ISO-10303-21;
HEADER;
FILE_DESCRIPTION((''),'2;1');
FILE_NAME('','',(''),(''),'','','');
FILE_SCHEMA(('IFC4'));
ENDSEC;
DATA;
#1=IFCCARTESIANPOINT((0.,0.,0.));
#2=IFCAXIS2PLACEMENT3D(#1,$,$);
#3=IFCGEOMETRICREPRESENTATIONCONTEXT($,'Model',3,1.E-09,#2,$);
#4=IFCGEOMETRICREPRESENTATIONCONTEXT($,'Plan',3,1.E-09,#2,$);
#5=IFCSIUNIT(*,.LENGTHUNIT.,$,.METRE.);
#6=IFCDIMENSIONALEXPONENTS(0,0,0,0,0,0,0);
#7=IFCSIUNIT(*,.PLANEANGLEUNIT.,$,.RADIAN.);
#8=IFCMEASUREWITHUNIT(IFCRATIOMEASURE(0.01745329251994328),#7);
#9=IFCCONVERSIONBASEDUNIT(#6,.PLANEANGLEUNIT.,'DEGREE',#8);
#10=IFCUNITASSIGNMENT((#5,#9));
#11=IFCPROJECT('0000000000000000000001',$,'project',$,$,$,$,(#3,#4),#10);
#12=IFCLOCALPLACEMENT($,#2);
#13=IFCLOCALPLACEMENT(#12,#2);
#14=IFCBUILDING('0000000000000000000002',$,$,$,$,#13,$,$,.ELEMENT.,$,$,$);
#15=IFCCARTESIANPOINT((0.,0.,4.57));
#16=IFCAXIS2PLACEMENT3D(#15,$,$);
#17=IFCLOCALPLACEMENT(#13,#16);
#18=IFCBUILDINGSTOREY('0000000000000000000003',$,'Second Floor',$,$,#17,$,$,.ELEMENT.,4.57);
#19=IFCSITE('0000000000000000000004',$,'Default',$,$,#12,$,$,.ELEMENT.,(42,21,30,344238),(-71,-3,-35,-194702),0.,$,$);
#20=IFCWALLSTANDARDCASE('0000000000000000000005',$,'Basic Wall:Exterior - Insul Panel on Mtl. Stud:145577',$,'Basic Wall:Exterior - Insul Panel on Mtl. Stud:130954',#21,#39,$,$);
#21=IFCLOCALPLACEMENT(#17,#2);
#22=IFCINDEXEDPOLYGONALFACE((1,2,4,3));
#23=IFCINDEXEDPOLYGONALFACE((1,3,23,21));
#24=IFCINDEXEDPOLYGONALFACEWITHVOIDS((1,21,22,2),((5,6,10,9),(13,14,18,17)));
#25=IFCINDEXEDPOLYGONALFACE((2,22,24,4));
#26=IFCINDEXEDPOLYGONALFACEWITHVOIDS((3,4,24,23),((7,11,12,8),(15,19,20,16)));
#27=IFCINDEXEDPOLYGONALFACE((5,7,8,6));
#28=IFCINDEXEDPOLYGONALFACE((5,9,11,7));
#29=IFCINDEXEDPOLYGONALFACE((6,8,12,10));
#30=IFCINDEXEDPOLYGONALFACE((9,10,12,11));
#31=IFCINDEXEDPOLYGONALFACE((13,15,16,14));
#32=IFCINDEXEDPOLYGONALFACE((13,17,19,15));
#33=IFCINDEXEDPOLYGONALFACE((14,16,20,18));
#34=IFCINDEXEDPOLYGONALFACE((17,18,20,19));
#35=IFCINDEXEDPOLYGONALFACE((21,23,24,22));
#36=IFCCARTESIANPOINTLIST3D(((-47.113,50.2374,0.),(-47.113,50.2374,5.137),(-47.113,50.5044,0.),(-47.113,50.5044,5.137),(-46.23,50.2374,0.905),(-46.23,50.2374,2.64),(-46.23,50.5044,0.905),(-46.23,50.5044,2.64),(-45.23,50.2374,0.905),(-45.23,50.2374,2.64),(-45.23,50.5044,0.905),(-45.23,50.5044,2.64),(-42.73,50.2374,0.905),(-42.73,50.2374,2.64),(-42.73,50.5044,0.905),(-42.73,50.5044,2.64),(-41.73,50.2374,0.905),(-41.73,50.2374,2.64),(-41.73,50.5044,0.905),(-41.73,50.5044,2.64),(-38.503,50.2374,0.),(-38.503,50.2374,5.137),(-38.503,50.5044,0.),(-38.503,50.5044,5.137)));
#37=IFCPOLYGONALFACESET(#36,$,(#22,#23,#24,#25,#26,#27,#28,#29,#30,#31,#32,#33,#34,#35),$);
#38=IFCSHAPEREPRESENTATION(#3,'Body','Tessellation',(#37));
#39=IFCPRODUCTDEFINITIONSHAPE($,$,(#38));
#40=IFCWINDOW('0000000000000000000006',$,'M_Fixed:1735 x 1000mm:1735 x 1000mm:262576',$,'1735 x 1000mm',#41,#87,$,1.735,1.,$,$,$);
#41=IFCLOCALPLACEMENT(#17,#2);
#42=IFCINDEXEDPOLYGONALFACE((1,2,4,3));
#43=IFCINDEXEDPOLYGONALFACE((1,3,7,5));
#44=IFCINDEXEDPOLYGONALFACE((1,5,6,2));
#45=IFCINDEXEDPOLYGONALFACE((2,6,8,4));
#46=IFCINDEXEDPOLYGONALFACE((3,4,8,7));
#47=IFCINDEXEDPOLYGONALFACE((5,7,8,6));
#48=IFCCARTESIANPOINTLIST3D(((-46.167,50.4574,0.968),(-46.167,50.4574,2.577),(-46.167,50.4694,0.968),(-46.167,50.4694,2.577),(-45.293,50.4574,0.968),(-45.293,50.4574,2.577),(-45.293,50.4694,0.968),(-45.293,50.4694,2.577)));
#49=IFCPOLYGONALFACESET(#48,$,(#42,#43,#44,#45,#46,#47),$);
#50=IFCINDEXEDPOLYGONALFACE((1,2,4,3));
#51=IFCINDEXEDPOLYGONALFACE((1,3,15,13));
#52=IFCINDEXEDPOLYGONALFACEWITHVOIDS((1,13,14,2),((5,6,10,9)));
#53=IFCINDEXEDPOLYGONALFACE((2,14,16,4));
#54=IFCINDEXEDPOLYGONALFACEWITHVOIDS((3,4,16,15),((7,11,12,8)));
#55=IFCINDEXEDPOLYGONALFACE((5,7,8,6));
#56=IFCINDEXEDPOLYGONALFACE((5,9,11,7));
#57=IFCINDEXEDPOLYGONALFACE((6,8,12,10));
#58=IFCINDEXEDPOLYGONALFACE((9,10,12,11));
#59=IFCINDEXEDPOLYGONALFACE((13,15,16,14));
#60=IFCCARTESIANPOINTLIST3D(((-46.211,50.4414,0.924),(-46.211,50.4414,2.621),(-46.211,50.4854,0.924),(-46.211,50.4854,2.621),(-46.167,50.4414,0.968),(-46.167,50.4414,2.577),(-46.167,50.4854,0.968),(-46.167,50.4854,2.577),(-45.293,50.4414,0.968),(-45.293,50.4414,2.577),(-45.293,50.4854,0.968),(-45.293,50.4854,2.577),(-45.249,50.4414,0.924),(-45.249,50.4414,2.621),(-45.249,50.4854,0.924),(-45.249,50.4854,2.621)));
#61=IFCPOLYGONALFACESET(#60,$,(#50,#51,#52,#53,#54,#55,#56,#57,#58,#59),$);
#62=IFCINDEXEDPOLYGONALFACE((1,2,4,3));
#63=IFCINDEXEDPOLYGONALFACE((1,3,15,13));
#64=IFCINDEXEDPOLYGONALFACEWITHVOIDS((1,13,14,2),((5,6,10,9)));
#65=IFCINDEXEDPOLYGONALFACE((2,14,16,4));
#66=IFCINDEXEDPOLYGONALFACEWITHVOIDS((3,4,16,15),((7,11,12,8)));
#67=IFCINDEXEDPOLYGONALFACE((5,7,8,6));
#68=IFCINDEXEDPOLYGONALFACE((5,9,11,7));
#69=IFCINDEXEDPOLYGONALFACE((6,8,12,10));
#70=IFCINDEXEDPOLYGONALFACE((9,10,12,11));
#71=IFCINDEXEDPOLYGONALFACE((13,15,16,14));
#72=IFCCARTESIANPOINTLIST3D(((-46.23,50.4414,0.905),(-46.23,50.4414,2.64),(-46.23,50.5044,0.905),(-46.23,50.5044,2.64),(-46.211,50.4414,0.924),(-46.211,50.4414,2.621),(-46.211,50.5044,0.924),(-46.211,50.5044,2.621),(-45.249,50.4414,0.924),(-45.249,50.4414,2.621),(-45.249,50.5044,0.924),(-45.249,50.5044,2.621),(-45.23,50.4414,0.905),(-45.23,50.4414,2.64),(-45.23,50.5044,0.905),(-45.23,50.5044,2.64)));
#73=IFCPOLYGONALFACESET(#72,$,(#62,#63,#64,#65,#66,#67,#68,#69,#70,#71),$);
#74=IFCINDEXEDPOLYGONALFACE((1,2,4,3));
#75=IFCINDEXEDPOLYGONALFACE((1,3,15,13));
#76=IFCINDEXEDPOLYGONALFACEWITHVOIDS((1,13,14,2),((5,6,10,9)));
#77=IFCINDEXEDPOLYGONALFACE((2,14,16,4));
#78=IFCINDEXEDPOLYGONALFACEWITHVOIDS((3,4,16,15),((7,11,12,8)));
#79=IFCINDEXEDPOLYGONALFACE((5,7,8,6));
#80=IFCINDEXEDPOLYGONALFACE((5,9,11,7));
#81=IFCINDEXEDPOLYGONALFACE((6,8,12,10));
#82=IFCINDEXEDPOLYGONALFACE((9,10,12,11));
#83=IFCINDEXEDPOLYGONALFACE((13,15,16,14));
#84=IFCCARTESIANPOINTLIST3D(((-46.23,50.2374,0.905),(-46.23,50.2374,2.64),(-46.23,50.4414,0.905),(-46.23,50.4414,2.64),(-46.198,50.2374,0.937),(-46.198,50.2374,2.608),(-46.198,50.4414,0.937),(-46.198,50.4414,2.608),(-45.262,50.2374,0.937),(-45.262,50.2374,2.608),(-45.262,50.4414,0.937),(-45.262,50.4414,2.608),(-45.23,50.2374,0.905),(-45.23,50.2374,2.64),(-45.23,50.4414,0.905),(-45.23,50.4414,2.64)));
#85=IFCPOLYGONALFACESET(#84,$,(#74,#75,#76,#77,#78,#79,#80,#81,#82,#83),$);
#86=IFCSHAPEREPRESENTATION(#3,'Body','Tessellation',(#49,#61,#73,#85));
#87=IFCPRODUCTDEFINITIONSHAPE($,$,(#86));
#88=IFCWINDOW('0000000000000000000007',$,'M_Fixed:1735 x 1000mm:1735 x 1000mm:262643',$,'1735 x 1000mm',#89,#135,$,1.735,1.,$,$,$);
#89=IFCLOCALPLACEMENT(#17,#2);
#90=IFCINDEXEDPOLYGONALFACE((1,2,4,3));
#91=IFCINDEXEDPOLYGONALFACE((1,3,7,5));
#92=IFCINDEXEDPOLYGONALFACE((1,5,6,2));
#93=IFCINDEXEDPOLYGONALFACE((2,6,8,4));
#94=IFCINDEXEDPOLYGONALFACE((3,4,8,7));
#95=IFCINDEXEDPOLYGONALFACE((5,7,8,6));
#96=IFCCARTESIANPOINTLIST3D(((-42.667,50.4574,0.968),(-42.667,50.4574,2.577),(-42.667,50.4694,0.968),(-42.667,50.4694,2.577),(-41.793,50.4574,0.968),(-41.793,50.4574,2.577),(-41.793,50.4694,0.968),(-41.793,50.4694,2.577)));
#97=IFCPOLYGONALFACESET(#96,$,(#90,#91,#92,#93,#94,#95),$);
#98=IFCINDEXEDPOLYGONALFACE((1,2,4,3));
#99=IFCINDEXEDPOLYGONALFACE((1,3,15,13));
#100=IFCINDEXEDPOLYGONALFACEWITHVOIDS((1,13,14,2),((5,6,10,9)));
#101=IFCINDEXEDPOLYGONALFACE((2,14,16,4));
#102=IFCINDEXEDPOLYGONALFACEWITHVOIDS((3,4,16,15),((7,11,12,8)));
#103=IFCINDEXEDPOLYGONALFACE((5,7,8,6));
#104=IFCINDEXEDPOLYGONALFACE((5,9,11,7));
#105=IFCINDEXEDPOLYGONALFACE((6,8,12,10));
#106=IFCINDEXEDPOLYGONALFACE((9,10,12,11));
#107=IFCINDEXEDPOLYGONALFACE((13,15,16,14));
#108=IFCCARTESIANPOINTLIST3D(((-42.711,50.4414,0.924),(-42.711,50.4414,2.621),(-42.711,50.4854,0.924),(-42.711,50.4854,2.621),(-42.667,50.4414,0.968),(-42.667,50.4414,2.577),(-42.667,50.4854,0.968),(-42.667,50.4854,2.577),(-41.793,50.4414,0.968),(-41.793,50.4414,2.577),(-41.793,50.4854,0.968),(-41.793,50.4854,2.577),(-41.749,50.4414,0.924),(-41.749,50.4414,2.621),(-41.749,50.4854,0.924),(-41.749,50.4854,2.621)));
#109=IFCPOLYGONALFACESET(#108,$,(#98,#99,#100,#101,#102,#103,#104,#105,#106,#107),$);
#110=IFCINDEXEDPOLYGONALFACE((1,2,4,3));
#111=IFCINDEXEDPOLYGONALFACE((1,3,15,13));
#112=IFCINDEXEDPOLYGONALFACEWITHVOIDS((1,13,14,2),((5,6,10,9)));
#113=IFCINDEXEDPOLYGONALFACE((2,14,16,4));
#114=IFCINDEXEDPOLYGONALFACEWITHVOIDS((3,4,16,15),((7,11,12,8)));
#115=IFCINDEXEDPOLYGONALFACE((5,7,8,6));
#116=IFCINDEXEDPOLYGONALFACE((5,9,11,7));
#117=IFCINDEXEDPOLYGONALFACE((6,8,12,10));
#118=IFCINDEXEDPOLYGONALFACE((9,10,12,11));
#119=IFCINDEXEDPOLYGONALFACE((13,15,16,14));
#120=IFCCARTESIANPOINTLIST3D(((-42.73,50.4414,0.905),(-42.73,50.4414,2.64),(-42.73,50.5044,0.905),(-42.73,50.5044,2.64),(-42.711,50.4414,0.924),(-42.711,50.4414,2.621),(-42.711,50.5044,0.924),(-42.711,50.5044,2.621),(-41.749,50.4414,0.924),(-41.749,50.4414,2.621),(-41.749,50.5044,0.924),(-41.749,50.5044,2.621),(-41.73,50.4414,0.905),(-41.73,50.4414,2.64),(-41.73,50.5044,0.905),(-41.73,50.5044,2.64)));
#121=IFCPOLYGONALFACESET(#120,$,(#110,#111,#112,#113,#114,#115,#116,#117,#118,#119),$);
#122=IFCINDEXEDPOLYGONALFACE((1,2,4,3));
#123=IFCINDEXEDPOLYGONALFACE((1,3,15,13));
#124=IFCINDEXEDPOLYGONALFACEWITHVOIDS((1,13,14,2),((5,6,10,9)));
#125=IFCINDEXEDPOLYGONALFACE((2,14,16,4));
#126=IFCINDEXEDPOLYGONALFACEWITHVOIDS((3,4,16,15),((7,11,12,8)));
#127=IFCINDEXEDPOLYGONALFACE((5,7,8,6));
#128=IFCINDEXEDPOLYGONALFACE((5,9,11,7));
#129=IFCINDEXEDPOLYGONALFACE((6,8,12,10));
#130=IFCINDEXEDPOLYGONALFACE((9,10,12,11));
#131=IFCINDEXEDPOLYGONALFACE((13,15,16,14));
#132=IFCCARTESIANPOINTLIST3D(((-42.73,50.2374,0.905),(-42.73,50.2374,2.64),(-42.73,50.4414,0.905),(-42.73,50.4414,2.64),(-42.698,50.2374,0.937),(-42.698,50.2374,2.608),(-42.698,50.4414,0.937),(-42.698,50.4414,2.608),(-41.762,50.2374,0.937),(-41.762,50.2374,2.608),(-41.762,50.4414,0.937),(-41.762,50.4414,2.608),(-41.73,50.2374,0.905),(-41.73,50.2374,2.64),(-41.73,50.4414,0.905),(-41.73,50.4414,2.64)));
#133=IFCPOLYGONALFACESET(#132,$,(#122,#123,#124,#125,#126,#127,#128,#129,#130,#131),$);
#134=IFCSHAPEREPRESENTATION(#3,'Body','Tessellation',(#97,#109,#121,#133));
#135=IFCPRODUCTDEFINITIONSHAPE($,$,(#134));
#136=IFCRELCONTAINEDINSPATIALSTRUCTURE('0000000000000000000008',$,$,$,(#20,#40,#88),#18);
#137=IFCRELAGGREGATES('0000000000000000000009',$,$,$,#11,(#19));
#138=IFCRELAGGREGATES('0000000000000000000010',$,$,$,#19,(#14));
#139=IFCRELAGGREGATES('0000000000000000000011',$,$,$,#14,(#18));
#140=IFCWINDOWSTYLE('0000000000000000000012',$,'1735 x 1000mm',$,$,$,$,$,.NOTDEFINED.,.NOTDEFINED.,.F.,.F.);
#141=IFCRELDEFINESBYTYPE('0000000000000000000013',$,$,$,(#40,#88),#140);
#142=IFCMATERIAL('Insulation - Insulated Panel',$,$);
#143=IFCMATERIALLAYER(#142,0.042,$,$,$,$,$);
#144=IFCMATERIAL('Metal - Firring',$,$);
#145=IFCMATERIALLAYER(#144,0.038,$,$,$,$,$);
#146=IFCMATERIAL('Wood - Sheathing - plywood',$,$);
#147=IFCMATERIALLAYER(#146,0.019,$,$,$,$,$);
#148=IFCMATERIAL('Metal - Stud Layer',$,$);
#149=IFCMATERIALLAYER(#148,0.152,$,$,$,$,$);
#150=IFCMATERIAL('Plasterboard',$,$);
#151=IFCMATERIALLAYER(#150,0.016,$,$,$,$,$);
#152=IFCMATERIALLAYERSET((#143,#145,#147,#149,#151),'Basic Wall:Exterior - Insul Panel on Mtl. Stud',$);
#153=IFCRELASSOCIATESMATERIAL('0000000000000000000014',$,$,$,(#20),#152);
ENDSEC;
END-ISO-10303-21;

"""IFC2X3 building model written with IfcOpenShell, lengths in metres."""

from ifc_helpers import new_model, entity, si_unit, converted_unit, frame, frame_2d, origin, origin_2d_with_axis, place, context, project, spatial, polyline, rectangle, outline, extrude, source, transform, mapped, material, layer, layer_set, layer_usage, type_object, type_shapes, element, fill, save


model = new_model("IFC2X3")

# Units and contexts
model_context = context("Model", 3, precision=1e-09, world=origin())
plan_context = context("Plan", 3, precision=1e-09, world=origin())
ifc_project = project(units=[si_unit("LENGTHUNIT", "METRE"), converted_unit("PLANEANGLEUNIT", "DEGREE", entity("IfcRatioMeasure", 0.01745329251994328), si_unit("PLANEANGLEUNIT", "RADIAN"), dimensions=[0, 0, 0, 0, 0, 0, 0])], contexts=[model_context, plan_context])

# Site, building, storey
site_placement = place(None, origin())
site = spatial("IfcSite", under=ifc_project, at=site_placement, Name="Default", CompositionType="ELEMENT", RefLatitude=(42, 21, 30, 344238), RefLongitude=(-71, -3, -35, -194702), RefElevation=0.0)
building_placement = place(site_placement, origin())
building = spatial("IfcBuilding", under=site, at=building_placement, CompositionType="ELEMENT")
storey_placement = place(building_placement, frame((0.0, 0.0, 4.57)))
storey = spatial("IfcBuildingStorey", under=building, at=storey_placement, Name="Second Floor", CompositionType="ELEMENT", Elevation=4.57)

# Wall, openings, windows
ifc_material_1 = material(Name="Insulation - Insulated Panel")
ifc_layer_1 = layer(ifc_material_1, 0.042)
ifc_material_2 = material(Name="Metal - Firring")
ifc_layer_2 = layer(ifc_material_2, 0.038)
ifc_material_3 = material(Name="Wood - Sheathing - plywood")
ifc_layer_3 = layer(ifc_material_3, 0.019)
ifc_material_4 = material(Name="Metal - Stud Layer")
ifc_layer_4 = layer(ifc_material_4, 0.152)
ifc_material_5 = material(Name="Plasterboard")
ifc_layer_5 = layer(ifc_material_5, 0.016)
ifc_layer_set_1 = layer_set([ifc_layer_1, ifc_layer_2, ifc_layer_3, ifc_layer_4, ifc_layer_5], Name="Basic Wall:Exterior - Insul Panel on Mtl. Stud")
ifc_layer_usage_1 = layer_usage(ifc_layer_set_1, "AXIS2", "NEGATIVE", 0.1335)
wall_1_placement = place(storey_placement, frame((-47.113, 50.3709, 0.0)))
wall_1 = element("IfcWallStandardCase", 1, at=wall_1_placement, inside=storey, material=ifc_layer_usage_1, Name="Basic Wall:Exterior - Insul Panel on Mtl. Stud:145577", ObjectType="Basic Wall:Exterior - Insul Panel on Mtl. Stud:130954", context=model_context, shape_type="SweptSolid", body=[
    extrude(rectangle(XDim=8.61, YDim=0.267, at=frame_2d((4.305, 0.0), x_axis=(-1.0, 0.0))), origin(), (0.0, 0.0, 1.0), 5.137),
])
opening_1_placement = place(wall_1_placement, frame((0.883, -0.1335, 0.905)))
opening_1 = element("IfcOpeningElement", 2, at=opening_1_placement, cuts=wall_1, ObjectType="Opening", context=model_context, shape_type="SweptSolid", body=[
    extrude(rectangle(XDim=1.735, YDim=1.0, at=frame_2d((0.8675, 0.5), x_axis=(1.0, 0.0))), frame((0.0, 0.0, 0.0), z_axis=(0.0, 1.0, 0.0), x_axis=(0.0, 0.0, 1.0)), (0.0, 0.0, 1.0), 0.267),
])
opening_2_placement = place(wall_1_placement, frame((4.383, -0.1335, 0.905)))
opening_2 = element("IfcOpeningElement", 3, at=opening_2_placement, cuts=wall_1, ObjectType="Opening", context=model_context, shape_type="SweptSolid", body=[
    extrude(rectangle(XDim=1.735, YDim=1.0, at=frame_2d((0.8675, 0.5), x_axis=(1.0, 0.0))), frame((0.0, 0.0, 0.0), z_axis=(0.0, 1.0, 0.0), x_axis=(0.0, 0.0, 1.0)), (0.0, 0.0, 1.0), 0.267),
])
window_style = type_object("IfcWindowStyle", Name="1735 x 1000mm", ConstructionType="NOTDEFINED", OperationType="NOTDEFINED", ParameterTakesPrecedence=False, Sizeable=False)
shared_shape_1 = source(origin(), model_context, "Body", "SweptSolid", [
    extrude(rectangle(XDim=0.012, YDim=0.874, at=origin_2d_with_axis()), frame((0.5, 0.226, 0.063), z_axis=(0.0, 0.0, 1.0), x_axis=(0.0, -1.0, 0.0)), (0.0, 0.0, 1.0), 1.609),
    extrude(outline(polyline([(-0.481, -0.8485), (0.481, -0.8485), (0.481, 0.8485), (-0.481, 0.8485), (-0.481, -0.8485)]), holes=[polyline([(-0.437, -0.8045), (-0.437, 0.8045), (0.437, 0.8045), (0.437, -0.8045), (-0.437, -0.8045)])]), frame((0.5, 0.204, 0.8675), z_axis=(0.0, 1.0, 0.0), x_axis=(1.0, 0.0, 0.0)), (0.0, 0.0, 1.0), 0.044),
    extrude(outline(polyline([(-0.5, -0.8675), (0.5, -0.8675), (0.5, 0.8675), (-0.5, 0.8675), (-0.5, -0.8675)]), holes=[polyline([(-0.481, -0.8485), (-0.481, 0.8485), (0.481, 0.8485), (0.481, -0.8485), (-0.481, -0.8485)])]), frame((0.5, 0.204, 0.8675), z_axis=(0.0, 1.0, 0.0), x_axis=(1.0, 0.0, 0.0)), (0.0, 0.0, 1.0), 0.063),
    extrude(outline(polyline([(-0.5, -0.8675), (0.5, -0.8675), (0.5, 0.8675), (-0.5, 0.8675), (-0.5, -0.8675)]), holes=[polyline([(-0.468, -0.8355), (-0.468, 0.8355), (0.468, 0.8355), (0.468, -0.8355), (-0.468, -0.8355)])]), frame((0.5, 0.0, 0.8675), z_axis=(0.0, 1.0, 0.0), x_axis=(1.0, 0.0, 0.0)), (0.0, 0.0, 1.0), 0.204),
])
type_shapes(window_style, [shared_shape_1])
window_1_placement = place(opening_1_placement, origin())
window_1 = element("IfcWindow", 4, at=window_1_placement, inside=storey, type_object=window_style, Name="M_Fixed:1735 x 1000mm:1735 x 1000mm:262576", ObjectType="1735 x 1000mm", OverallHeight=1.735, OverallWidth=1.0, context=model_context, shape_type="MappedRepresentation", body=[
    mapped(shared_shape_1, transform((0.0, 0.0, 0.0), scale=1.0)),
])
fill(opening_1, window_1)
window_2_placement = place(opening_2_placement, origin())
window_2 = element("IfcWindow", 5, at=window_2_placement, inside=storey, type_object=window_style, Name="M_Fixed:1735 x 1000mm:1735 x 1000mm:262643", ObjectType="1735 x 1000mm", OverallHeight=1.735, OverallWidth=1.0, context=model_context, shape_type="MappedRepresentation", body=[
    mapped(shared_shape_1, transform((0.0, 0.0, 0.0), scale=1.0)),
])
fill(opening_2, window_2)

save(model, "model.ifc")
